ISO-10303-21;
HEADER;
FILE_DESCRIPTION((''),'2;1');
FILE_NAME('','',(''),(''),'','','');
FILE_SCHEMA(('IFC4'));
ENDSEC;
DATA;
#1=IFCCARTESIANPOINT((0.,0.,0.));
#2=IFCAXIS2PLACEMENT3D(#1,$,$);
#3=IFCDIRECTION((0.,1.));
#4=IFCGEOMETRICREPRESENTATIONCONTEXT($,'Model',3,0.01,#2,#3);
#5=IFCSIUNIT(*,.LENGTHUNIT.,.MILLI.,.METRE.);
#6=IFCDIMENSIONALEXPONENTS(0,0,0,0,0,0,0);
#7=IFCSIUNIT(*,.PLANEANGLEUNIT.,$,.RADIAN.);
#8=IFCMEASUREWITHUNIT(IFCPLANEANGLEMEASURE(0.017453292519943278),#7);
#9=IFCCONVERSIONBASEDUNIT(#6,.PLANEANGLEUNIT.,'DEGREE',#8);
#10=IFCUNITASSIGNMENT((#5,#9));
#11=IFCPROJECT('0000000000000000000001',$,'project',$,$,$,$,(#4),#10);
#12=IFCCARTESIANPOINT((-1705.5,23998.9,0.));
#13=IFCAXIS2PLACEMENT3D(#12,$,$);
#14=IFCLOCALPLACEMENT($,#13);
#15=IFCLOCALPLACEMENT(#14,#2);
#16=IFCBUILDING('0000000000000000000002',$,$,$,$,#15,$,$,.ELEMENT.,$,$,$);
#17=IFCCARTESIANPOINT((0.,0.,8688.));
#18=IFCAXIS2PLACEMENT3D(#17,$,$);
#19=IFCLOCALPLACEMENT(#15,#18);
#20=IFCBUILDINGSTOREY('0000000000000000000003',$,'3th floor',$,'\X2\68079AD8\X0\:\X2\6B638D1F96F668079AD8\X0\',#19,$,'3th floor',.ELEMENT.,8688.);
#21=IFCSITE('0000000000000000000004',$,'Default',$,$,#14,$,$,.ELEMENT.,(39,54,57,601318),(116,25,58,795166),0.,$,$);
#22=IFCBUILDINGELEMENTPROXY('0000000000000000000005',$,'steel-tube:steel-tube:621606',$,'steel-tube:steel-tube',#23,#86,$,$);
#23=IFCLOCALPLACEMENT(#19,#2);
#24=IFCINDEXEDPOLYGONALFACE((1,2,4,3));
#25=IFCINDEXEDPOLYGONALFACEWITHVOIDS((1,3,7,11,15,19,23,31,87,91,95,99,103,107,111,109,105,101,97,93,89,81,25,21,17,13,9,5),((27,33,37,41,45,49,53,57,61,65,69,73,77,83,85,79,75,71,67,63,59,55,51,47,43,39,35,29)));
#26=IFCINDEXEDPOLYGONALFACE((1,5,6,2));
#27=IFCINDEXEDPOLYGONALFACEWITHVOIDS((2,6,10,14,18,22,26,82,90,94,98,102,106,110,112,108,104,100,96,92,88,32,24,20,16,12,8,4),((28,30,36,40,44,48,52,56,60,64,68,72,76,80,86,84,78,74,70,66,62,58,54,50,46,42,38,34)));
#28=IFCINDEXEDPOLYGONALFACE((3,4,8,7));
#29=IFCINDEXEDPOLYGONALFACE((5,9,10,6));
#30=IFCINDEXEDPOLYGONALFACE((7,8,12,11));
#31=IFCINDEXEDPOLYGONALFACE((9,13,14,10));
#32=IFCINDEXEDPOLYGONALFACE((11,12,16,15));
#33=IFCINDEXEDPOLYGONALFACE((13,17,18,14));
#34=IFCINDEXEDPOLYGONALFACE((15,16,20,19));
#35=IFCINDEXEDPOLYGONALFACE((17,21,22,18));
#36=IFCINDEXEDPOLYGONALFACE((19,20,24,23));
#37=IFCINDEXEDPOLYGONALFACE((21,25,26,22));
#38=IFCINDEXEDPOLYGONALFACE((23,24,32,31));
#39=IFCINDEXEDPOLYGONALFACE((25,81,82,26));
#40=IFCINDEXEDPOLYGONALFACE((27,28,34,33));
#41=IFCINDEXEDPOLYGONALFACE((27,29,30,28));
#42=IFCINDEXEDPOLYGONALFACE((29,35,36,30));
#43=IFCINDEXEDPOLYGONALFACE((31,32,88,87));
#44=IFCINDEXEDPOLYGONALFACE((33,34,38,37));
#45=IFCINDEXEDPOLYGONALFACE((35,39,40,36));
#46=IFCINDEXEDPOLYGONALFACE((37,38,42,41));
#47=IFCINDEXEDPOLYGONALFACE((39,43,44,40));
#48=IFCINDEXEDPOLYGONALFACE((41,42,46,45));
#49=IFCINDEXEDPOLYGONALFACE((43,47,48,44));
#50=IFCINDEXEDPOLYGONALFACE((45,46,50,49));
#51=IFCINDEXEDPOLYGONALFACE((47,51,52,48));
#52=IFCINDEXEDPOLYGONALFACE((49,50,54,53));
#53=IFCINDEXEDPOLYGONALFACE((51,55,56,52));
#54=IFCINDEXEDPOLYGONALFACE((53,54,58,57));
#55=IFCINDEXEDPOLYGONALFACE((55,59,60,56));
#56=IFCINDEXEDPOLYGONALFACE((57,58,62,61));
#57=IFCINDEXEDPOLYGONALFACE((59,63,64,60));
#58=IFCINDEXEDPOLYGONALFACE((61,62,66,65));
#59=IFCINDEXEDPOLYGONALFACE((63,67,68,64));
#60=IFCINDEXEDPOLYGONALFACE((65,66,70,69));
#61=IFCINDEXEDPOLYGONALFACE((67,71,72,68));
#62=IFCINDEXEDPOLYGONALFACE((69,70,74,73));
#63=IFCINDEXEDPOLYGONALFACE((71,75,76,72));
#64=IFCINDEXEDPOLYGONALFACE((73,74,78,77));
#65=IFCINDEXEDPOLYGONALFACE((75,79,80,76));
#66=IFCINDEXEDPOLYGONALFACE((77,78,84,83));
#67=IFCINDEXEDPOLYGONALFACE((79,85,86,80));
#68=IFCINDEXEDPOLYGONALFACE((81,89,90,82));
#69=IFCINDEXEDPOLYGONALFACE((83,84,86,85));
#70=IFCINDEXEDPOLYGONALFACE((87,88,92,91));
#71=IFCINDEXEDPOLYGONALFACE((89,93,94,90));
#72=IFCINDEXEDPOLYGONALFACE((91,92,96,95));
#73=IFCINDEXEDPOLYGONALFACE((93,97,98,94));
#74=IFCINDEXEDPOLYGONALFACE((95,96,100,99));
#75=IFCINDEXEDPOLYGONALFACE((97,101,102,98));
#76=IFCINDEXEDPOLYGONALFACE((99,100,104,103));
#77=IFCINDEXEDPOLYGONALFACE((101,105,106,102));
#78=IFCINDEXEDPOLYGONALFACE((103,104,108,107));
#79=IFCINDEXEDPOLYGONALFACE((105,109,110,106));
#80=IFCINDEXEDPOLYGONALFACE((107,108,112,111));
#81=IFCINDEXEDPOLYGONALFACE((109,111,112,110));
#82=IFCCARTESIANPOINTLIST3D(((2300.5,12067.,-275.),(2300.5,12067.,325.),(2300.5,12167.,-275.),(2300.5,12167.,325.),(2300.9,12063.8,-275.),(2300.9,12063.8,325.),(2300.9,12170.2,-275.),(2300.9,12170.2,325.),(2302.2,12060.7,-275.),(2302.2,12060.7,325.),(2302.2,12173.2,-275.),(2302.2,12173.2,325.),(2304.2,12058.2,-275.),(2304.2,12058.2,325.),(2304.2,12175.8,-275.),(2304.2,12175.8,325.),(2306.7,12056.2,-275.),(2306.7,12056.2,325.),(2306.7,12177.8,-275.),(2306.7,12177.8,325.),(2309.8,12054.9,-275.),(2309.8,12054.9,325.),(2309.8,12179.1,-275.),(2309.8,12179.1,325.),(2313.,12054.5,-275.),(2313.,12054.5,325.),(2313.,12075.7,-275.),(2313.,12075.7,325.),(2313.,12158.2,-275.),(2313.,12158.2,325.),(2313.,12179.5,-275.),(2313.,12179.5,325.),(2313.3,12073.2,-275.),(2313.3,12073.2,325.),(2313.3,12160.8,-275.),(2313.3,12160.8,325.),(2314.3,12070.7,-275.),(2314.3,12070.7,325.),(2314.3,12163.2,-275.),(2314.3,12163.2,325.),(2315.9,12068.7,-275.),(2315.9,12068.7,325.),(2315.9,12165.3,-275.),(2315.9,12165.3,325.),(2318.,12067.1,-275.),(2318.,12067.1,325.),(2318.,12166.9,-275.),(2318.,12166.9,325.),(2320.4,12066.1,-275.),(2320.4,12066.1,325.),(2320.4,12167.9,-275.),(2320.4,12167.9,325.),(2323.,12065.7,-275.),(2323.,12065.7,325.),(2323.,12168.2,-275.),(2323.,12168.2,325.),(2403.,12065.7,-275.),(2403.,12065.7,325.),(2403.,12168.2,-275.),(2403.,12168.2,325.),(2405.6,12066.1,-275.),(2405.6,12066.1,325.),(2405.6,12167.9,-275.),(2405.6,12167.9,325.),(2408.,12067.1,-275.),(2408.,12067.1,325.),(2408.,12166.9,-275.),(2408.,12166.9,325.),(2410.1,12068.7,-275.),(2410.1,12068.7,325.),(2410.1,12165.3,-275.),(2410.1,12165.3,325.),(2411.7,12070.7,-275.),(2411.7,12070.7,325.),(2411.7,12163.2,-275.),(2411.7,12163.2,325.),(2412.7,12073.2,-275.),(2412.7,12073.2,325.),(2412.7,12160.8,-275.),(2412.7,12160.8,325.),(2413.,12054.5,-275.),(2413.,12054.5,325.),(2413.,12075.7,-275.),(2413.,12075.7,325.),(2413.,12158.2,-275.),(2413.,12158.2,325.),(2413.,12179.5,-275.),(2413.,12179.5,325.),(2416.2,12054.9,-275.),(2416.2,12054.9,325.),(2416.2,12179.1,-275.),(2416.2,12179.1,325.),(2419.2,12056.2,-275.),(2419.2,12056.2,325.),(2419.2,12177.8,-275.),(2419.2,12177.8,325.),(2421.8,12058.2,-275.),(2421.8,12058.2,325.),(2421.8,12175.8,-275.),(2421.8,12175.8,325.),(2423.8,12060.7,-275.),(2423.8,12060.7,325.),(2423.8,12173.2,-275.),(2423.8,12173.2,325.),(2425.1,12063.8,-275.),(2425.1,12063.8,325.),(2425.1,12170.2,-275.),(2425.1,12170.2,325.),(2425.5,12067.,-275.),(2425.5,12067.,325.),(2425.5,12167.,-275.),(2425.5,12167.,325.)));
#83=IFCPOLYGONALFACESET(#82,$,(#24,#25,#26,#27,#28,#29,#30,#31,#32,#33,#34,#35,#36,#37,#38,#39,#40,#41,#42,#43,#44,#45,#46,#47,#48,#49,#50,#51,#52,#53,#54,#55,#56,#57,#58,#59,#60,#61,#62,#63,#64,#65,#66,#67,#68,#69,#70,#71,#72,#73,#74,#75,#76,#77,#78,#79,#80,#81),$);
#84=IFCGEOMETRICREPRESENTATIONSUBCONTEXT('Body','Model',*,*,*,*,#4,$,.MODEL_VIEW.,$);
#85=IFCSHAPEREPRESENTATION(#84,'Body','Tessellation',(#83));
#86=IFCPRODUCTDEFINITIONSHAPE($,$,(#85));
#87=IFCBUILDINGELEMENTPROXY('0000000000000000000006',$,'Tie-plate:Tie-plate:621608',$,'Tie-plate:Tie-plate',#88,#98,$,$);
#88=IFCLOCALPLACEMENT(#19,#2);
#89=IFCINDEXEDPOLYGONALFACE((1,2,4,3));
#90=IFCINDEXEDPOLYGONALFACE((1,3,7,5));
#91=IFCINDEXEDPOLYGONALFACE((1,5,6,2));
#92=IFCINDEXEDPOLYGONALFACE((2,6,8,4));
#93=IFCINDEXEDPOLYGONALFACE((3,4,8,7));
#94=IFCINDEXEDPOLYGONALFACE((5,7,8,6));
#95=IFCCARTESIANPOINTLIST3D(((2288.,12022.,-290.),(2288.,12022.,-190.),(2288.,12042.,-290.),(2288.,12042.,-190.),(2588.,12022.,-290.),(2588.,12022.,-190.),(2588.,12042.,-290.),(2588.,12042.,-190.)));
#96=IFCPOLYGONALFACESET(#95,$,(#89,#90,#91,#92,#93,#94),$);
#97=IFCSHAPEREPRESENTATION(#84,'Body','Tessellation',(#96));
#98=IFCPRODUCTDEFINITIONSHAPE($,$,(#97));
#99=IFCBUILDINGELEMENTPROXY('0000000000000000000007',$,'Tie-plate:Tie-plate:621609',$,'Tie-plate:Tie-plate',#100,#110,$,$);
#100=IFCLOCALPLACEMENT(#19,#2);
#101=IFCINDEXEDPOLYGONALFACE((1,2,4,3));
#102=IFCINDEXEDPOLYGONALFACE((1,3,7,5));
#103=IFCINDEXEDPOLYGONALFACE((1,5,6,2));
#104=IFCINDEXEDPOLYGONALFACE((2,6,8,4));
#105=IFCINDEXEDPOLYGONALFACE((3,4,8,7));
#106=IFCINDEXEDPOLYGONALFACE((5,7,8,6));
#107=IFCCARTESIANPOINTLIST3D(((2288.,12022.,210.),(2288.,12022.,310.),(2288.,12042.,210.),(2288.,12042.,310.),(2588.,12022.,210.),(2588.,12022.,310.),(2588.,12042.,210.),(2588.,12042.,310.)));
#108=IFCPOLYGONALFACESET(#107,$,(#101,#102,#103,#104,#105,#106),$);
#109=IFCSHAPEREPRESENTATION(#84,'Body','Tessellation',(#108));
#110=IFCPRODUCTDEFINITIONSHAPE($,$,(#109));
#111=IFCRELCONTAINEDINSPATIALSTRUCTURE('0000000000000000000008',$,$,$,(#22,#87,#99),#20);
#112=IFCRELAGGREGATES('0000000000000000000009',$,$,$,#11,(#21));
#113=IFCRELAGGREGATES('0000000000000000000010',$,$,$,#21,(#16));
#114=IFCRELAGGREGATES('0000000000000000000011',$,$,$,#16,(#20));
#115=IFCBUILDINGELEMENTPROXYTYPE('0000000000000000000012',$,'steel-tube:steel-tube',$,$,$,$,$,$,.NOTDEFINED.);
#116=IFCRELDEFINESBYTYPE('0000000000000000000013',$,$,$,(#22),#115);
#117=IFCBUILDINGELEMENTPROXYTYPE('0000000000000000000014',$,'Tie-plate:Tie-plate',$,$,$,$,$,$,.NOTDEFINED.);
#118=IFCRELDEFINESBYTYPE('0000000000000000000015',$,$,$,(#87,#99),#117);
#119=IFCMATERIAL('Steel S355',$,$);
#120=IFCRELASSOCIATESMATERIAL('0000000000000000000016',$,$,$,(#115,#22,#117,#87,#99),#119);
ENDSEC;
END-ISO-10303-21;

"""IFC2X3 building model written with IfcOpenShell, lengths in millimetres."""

from ifc_helpers import new_model, entity, si_unit, converted_unit, direction, frame, frame_2d, origin, place, context, subcontext, project, spatial, polyline, circle_curve, parameter, trimmed, segment, composite_curve, rectangle, outline, extrude, source, transform, mapped, material, type_object, type_shapes, element, save


model = new_model("IFC2X3")

# Units and contexts
model_context = context("Model", 3, precision=0.01, world=origin(), true_north=direction((0.0, 1.0)))
body_context = subcontext(model_context, "Body", "Model", "MODEL_VIEW")
ifc_project = project(units=[si_unit("LENGTHUNIT", "METRE", prefix="MILLI"), converted_unit("PLANEANGLEUNIT", "DEGREE", entity("IfcPlaneAngleMeasure", 0.017453292519943278), si_unit("PLANEANGLEUNIT", "RADIAN"), dimensions=[0, 0, 0, 0, 0, 0, 0])], contexts=[model_context])

# Site, building, storey
site_placement = place(None, frame((-1705.5, 23998.9, 0.0)))
site = spatial("IfcSite", under=ifc_project, at=site_placement, Name="Default", CompositionType="ELEMENT", RefLatitude=(39, 54, 57, 601318), RefLongitude=(116, 25, 58, 795166), RefElevation=0.0)
building_placement = place(site_placement, origin())
building = spatial("IfcBuilding", under=site, at=building_placement, CompositionType="ELEMENT")
storey_placement = place(building_placement, frame((0.0, 0.0, 8688.0)))
storey = spatial("IfcBuildingStorey", under=building, at=storey_placement, Name="3th floor", ObjectType="标高:正负零标高", LongName="3th floor", CompositionType="ELEMENT", Elevation=8688.0)

# Shared definitions
ifc_material_1 = material(Name="Steel S355")

# Building element proxies
building_element_proxy_type_1 = type_object("IfcBuildingElementProxyType", Name="steel-tube:steel-tube", PredefinedType="NOTDEFINED", material=ifc_material_1)
shared_shape_1 = source(origin(), body_context, "Body", "SweptSolid", [
    extrude(outline(composite_curve([segment(trimmed(circle_curve(frame_2d((50.0, -50.0), x_axis=(1.0, 0.0)), 12.5), [parameter(270.0)], [parameter(0.0)], True, "PARAMETER"), True, "CONTINUOUS"), segment(polyline([(62.5, -50.0), (62.5, 50.0)]), True, "CONTINUOUS"), segment(trimmed(circle_curve(frame_2d((50.0, 50.0), x_axis=(1.0, 0.0)), 12.5), [parameter(0.0)], [parameter(90.0)], True, "PARAMETER"), True, "CONTINUOUS"), segment(polyline([(50.0, 62.5), (-50.0, 62.5)]), True, "CONTINUOUS"), segment(trimmed(circle_curve(frame_2d((-50.0, 50.0), x_axis=(1.0, 0.0)), 12.5), [parameter(90.0)], [parameter(180.0)], True, "PARAMETER"), True, "CONTINUOUS"), segment(polyline([(-62.5, 50.0), (-62.5, -50.0)]), True, "CONTINUOUS"), segment(trimmed(circle_curve(frame_2d((-50.0, -50.0), x_axis=(1.0, 0.0)), 12.5), [parameter(180.0)], [parameter(270.0)], True, "PARAMETER"), True, "CONTINUOUS"), segment(polyline([(-50.0, -62.5), (50.0, -62.5)]), True, "CONTINUOUS")], self_intersect=False), holes=[composite_curve([segment(trimmed(circle_curve(frame_2d((-41.2, 40.0), x_axis=(1.0, 0.0)), 10.0), [parameter(90.0)], [parameter(180.0)], True, "PARAMETER"), False, "CONTINUOUS"), segment(polyline([(-41.3, 50.0), (41.2, 50.0)]), True, "CONTINUOUS"), segment(trimmed(circle_curve(frame_2d((41.2, 40.0), x_axis=(1.0, 0.0)), 10.0), [parameter(0.0)], [parameter(90.0)], True, "PARAMETER"), False, "CONTINUOUS"), segment(polyline([(51.2, 40.0), (51.2, -40.0)]), True, "CONTINUOUS"), segment(trimmed(circle_curve(frame_2d((41.2, -40.0), x_axis=(1.0, 0.0)), 10.0), [parameter(270.0)], [parameter(360.0)], True, "PARAMETER"), False, "CONTINUOUS"), segment(polyline([(41.2, -50.0), (-41.3, -50.0)]), True, "CONTINUOUS"), segment(trimmed(circle_curve(frame_2d((-41.3, -40.0), x_axis=(1.0, 0.0)), 10.0), [parameter(180.0)], [parameter(270.0)], True, "PARAMETER"), False, "CONTINUOUS"), segment(polyline([(-51.3, -40.0), (-51.3, 40.0)]), True, "CONTINUOUS")], self_intersect=False)]), frame((62.5, 62.5, -175.0)), (0.0, 0.0, 1.0), 600.0),
])
type_shapes(building_element_proxy_type_1, [shared_shape_1])
for number, where, z_axis, x_axis, name in (
    (1, (2300.5, 12179.5, -100.0), (0.0, 0.0, 1.0), (0.0, -1.0, 0.0), "steel-tube:steel-tube:621606"),
):
    element("IfcBuildingElementProxy", number, at=place(storey_placement, frame(where, z_axis=z_axis, x_axis=x_axis)), inside=storey, type_object=building_element_proxy_type_1, material=ifc_material_1, Name=name, ObjectType="steel-tube:steel-tube", context=body_context, shape_type="MappedRepresentation", body=[
        mapped(shared_shape_1, transform((0.0, 0.0, 0.0), scale=1.0)),
    ])
building_element_proxy_type_2 = type_object("IfcBuildingElementProxyType", Name="Tie-plate:Tie-plate", PredefinedType="NOTDEFINED", material=ifc_material_1)
shared_shape_2 = source(origin(), body_context, "Body", "SweptSolid", [
    extrude(rectangle(XDim=300.0, YDim=20.0, at=frame_2d((0.0, 0.0), x_axis=(1.0, 0.0))), frame((150.0, -10.0, 0.0), z_axis=(0.0, 0.0, 1.0), x_axis=(-1.0, 0.0, 0.0)), (0.0, 0.0, 1.0), 100.0),
])
type_shapes(building_element_proxy_type_2, [shared_shape_2])
for number, where, name in (
    (2, (2288.0, 12042.0, -290.0), "Tie-plate:Tie-plate:621608"),
    (3, (2288.0, 12042.0, 210.0), "Tie-plate:Tie-plate:621609"),
):
    element("IfcBuildingElementProxy", number, at=place(storey_placement, frame(where)), inside=storey, type_object=building_element_proxy_type_2, material=ifc_material_1, Name=name, ObjectType="Tie-plate:Tie-plate", context=body_context, shape_type="MappedRepresentation", body=[
        mapped(shared_shape_2, transform((0.0, 0.0, 0.0), scale=1.0)),
    ])

save(model, "model.ifc")
